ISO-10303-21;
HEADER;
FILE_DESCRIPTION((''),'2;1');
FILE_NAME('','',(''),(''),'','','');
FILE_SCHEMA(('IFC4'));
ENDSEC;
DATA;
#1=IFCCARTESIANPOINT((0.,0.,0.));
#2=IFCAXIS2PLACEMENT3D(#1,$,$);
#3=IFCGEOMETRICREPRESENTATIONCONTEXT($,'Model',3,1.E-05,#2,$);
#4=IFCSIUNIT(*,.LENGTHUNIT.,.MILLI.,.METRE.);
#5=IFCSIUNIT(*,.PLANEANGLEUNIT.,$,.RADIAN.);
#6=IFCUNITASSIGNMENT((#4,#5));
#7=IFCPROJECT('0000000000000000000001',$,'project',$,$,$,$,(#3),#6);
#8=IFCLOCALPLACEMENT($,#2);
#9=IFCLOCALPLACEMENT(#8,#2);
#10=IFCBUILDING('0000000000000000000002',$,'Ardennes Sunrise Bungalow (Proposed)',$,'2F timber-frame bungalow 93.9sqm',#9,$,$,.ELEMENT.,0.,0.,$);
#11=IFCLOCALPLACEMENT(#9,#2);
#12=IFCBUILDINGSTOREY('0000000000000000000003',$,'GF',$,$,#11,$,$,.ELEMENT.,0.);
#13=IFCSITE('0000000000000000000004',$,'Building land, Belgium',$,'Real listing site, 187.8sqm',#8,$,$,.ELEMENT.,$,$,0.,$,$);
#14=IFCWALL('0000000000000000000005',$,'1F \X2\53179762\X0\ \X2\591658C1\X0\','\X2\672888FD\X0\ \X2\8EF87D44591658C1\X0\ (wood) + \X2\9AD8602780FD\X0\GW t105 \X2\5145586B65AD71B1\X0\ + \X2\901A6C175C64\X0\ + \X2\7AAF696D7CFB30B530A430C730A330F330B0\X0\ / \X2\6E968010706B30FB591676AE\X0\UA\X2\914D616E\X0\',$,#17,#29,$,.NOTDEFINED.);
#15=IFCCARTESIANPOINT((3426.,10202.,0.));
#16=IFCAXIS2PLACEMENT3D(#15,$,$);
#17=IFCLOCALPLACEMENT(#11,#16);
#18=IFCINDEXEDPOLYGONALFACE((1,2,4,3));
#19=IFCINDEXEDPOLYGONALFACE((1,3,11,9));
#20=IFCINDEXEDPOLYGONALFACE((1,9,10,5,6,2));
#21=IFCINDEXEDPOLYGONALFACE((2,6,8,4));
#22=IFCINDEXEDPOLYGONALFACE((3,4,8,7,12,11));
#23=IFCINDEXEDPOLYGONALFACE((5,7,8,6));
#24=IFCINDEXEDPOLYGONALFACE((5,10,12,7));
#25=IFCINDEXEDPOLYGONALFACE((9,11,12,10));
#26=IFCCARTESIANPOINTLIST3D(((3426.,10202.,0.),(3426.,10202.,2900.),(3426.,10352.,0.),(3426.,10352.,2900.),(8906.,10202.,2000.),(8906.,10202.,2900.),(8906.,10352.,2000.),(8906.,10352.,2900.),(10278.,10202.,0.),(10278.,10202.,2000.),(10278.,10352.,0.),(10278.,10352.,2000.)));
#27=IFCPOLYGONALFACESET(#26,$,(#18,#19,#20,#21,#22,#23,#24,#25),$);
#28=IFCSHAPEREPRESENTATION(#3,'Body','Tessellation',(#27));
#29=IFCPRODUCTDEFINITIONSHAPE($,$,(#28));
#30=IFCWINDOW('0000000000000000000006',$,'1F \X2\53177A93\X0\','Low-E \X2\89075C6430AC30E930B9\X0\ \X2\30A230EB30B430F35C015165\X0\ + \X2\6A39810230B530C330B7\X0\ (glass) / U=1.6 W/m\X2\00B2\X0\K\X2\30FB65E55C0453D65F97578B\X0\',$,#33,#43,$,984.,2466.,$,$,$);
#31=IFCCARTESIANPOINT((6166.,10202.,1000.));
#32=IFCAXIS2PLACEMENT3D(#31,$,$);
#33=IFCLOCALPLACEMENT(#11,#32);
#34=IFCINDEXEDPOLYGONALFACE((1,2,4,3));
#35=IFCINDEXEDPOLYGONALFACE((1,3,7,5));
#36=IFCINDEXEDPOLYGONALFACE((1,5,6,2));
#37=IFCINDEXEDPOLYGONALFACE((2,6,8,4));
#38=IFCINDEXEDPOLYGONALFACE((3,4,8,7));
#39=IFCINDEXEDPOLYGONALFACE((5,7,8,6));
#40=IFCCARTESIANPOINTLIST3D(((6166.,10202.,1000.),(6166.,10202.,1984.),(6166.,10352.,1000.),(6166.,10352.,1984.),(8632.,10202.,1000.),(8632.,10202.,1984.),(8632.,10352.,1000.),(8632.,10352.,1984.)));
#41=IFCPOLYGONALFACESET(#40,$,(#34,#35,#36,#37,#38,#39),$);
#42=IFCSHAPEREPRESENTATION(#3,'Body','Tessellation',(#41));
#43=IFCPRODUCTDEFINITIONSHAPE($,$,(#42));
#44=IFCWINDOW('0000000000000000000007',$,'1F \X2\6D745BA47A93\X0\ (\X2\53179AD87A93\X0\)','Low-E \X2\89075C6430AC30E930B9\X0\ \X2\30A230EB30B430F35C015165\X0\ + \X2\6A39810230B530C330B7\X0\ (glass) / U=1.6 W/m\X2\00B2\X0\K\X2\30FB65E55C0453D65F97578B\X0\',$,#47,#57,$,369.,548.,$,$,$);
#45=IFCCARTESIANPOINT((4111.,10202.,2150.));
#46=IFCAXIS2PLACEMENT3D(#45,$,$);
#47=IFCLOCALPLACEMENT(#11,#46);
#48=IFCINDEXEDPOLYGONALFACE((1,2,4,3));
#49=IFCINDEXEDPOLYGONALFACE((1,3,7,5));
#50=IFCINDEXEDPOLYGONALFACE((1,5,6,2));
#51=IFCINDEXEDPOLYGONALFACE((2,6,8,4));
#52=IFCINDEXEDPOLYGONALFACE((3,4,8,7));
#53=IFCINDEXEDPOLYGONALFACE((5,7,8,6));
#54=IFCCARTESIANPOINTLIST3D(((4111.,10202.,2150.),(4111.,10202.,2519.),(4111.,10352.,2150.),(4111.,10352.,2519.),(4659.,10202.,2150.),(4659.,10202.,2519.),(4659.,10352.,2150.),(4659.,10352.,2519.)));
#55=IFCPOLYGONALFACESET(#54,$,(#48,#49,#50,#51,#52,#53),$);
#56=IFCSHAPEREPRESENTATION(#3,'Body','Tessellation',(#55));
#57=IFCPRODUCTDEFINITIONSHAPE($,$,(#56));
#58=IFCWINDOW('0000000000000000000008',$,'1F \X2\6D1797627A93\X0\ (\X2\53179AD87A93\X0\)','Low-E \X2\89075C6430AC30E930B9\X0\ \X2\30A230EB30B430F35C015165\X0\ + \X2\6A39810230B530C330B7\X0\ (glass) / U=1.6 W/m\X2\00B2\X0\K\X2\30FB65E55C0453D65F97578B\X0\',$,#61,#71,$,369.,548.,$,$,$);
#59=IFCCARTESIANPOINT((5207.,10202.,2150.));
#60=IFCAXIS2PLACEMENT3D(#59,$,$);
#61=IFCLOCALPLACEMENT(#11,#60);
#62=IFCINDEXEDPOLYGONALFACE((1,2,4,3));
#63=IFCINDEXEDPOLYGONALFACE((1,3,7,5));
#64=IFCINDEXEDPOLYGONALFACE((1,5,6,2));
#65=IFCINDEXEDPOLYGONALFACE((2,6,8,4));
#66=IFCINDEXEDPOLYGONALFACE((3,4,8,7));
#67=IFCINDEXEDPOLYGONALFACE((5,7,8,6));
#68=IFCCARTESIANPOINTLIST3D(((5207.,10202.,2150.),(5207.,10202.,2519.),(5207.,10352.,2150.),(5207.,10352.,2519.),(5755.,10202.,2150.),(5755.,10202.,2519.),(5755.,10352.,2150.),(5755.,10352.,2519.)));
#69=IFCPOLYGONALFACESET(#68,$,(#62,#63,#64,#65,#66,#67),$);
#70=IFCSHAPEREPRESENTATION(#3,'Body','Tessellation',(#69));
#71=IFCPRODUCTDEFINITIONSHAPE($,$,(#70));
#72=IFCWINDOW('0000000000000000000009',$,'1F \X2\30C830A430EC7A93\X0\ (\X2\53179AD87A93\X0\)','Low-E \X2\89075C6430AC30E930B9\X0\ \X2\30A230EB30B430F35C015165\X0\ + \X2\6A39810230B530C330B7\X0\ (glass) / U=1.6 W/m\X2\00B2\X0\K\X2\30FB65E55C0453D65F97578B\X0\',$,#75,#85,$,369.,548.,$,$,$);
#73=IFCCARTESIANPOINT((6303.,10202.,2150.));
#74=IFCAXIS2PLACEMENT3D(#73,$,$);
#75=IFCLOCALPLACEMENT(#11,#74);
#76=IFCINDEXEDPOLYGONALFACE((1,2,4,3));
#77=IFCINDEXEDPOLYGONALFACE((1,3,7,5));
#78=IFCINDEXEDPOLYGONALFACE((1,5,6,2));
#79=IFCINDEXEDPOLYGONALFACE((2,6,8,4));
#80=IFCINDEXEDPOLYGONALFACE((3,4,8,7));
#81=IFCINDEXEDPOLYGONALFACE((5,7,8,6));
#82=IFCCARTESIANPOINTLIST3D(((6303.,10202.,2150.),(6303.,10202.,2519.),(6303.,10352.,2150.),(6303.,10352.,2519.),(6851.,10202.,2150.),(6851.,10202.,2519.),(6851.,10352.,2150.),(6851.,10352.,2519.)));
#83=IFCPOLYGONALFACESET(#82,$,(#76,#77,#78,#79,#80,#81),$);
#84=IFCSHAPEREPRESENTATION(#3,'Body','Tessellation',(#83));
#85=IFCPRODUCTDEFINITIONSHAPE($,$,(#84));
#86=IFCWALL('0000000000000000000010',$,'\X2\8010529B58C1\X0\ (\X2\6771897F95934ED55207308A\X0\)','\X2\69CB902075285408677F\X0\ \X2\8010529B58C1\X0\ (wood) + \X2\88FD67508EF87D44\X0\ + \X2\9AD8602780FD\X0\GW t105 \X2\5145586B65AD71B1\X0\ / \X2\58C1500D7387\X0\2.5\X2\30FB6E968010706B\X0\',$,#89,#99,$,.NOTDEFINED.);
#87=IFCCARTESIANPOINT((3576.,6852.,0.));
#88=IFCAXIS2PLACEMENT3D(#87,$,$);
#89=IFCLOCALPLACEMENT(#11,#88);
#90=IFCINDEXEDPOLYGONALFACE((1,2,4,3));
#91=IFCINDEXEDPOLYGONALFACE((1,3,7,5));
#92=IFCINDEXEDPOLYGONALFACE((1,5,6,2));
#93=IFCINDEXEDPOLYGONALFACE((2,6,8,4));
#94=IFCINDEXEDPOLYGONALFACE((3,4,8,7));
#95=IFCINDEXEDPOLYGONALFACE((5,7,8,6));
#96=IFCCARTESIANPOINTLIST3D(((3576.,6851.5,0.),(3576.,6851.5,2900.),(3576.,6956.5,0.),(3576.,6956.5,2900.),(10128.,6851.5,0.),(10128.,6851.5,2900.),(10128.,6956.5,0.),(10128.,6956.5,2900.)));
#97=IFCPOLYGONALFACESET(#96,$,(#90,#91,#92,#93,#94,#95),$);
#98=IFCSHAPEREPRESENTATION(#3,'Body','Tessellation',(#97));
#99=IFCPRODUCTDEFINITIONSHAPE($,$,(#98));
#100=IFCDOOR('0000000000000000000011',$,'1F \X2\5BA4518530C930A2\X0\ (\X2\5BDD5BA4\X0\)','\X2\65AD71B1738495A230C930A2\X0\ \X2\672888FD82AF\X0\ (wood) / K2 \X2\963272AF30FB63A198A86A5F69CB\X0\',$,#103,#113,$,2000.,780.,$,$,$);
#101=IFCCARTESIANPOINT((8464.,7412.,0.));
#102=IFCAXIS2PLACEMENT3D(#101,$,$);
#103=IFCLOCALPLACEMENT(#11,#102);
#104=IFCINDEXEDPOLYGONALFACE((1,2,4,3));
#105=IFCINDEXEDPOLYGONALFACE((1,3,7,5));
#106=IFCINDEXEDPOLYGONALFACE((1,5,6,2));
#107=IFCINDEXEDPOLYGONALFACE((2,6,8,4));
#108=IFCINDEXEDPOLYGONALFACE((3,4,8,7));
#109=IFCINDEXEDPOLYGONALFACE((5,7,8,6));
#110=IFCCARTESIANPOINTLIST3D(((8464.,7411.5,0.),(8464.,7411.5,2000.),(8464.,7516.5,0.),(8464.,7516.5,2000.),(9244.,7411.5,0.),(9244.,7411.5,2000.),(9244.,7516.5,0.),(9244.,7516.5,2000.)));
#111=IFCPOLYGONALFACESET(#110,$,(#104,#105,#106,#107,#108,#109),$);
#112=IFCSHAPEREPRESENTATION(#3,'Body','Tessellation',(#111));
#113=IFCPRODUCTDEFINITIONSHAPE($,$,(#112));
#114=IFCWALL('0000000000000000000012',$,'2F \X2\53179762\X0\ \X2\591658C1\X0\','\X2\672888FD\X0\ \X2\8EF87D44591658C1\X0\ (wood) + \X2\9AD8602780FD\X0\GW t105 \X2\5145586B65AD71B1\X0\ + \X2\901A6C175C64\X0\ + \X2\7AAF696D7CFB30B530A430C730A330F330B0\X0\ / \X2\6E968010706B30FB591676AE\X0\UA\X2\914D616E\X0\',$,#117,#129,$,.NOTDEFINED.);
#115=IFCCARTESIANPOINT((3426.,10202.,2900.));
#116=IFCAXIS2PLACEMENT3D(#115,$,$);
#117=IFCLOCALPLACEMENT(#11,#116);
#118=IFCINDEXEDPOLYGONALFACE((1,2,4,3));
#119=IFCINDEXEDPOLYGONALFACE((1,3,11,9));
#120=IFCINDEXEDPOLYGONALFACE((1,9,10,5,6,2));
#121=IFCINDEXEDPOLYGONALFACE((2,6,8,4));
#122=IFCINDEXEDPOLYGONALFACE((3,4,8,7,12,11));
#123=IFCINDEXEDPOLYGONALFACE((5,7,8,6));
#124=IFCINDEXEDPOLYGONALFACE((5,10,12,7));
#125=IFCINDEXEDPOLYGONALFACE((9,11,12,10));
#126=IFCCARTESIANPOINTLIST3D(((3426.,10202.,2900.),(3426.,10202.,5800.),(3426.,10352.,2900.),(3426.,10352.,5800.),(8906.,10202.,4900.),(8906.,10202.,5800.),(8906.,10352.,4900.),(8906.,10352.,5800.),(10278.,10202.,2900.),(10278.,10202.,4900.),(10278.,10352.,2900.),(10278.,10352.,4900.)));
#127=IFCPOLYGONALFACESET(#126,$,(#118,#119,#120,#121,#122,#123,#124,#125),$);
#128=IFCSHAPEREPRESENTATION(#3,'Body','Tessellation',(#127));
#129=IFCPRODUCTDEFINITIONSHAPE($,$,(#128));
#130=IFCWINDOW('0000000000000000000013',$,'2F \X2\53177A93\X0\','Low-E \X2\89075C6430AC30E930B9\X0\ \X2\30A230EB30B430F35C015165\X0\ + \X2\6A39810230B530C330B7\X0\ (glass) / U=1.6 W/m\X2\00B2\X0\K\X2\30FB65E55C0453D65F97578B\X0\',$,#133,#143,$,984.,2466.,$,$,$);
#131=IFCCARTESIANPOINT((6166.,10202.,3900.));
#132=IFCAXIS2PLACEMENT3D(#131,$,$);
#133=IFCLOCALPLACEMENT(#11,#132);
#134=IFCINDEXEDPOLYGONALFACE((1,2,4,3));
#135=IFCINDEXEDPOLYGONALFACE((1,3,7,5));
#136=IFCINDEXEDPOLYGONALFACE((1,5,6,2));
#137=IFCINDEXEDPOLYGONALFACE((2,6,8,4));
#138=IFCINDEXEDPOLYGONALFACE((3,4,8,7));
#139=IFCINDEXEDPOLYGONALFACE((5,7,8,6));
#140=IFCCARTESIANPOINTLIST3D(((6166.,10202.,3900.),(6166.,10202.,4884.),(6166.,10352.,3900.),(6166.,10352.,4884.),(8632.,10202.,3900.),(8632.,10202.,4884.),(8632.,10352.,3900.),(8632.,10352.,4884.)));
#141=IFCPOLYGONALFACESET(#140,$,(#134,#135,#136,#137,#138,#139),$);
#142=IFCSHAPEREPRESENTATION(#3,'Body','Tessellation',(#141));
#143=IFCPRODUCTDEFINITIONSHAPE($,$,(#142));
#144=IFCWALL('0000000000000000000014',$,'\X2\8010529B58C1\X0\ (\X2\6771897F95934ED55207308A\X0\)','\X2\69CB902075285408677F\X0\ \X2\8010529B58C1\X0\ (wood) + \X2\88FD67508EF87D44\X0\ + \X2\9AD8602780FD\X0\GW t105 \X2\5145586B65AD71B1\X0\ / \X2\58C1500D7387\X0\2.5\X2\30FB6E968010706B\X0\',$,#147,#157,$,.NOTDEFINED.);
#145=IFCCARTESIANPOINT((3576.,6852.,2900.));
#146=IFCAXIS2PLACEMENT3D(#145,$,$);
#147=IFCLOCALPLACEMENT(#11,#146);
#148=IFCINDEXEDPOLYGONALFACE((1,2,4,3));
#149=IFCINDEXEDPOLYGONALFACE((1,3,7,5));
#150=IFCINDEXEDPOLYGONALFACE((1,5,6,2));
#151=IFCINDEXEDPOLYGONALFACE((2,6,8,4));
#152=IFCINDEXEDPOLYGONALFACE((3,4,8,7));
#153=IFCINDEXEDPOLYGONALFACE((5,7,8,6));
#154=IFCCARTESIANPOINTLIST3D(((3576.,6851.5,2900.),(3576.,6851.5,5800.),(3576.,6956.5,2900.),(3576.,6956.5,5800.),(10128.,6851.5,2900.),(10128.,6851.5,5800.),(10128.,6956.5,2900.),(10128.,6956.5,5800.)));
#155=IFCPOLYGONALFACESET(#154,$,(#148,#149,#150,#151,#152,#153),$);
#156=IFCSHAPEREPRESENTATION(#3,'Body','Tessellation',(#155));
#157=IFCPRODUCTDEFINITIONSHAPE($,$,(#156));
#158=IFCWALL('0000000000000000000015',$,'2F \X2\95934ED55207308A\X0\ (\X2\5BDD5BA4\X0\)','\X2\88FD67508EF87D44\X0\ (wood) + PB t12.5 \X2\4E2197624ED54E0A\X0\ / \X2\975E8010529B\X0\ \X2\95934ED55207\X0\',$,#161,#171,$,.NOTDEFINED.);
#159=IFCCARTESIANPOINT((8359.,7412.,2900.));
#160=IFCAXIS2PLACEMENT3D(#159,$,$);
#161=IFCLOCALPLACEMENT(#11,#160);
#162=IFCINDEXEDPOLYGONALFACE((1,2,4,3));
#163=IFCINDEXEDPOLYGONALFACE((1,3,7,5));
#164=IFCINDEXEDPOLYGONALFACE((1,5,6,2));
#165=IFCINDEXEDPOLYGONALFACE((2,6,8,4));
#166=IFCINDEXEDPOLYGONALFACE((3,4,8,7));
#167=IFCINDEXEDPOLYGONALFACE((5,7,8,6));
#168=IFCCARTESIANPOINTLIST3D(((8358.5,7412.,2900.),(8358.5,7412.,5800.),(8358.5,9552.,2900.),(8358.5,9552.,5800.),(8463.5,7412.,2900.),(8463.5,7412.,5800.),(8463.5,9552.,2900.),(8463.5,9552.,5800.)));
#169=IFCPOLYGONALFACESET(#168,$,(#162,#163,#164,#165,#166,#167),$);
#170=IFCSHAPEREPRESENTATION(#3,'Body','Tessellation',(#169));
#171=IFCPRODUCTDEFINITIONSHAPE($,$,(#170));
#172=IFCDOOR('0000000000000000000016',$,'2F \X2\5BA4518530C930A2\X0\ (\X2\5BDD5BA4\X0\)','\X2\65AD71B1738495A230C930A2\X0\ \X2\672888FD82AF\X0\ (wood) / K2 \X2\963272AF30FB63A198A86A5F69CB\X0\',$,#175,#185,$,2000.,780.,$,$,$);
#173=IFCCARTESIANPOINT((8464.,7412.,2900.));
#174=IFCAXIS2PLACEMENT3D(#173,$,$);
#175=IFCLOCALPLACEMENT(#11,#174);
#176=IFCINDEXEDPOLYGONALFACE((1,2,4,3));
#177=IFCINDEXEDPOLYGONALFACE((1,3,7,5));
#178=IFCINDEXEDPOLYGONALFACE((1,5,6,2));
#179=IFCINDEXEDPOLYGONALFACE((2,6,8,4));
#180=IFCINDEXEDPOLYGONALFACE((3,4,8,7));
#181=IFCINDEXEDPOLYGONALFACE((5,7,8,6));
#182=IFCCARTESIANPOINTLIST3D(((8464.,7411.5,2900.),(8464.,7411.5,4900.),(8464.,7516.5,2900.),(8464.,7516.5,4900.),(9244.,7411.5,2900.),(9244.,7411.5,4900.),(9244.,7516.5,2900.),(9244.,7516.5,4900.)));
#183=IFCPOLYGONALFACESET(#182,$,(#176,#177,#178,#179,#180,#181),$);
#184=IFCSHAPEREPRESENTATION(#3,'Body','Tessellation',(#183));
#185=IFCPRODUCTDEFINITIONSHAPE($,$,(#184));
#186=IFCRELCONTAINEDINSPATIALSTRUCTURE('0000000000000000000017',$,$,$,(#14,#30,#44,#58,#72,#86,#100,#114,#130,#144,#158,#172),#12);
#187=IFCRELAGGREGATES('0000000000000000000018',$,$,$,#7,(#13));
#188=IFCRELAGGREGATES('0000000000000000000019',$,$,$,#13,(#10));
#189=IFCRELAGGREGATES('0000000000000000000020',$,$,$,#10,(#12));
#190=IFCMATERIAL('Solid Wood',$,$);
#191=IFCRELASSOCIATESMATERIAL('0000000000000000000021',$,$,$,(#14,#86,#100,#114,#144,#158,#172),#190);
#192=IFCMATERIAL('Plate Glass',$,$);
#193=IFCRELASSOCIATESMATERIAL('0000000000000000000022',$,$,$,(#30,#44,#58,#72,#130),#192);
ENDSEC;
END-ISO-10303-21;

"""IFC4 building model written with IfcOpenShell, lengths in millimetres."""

from ifc_helpers import new_model, si_unit, frame, frame_2d, origin, place, context, project, spatial, rectangle, extrude, material, element, fill, save


model = new_model("IFC4")

# Units and contexts
model_context = context("Model", 3, precision=1e-05, world=origin())
ifc_project = project(units=[si_unit("LENGTHUNIT", "METRE", prefix="MILLI"), si_unit("PLANEANGLEUNIT", "RADIAN")], contexts=[model_context])

# Site, building, storey
site_placement = place(None, origin())
site = spatial("IfcSite", under=ifc_project, at=site_placement, Name="Building land, Belgium", ObjectType="Real listing site, 187.8sqm", CompositionType="ELEMENT", RefElevation=0.0)
building_placement = place(site_placement, origin())
building = spatial("IfcBuilding", under=site, at=building_placement, Name="Ardennes Sunrise Bungalow (Proposed)", ObjectType="2F timber-frame bungalow 93.9sqm", CompositionType="ELEMENT", ElevationOfRefHeight=0.0, ElevationOfTerrain=0.0)
storey_placement = place(building_placement, origin())
storey = spatial("IfcBuildingStorey", under=building, at=storey_placement, Name="GF", CompositionType="ELEMENT", Elevation=0.0)

# Wall, openings, windows
ifc_material_1 = material(Name="Solid Wood")
wall_1_placement = place(storey_placement, frame((3426.0, 10202.0, 0.0)))
wall_1 = element("IfcWall", 1, at=wall_1_placement, inside=storey, material=ifc_material_1, Name="1F 北面 外壁", Description="木製 軸組外壁 (wood) + 高性能GW t105 充填断熱 + 通気層 + 窯業系サイディング / 準耐火・外皮UA配慮", PredefinedType="NOTDEFINED", context=model_context, shape_type="SweptSolid", body=[
    extrude(rectangle(XDim=6852.0, YDim=150.0, at=frame_2d((3426.0, 75.0))), frame((3426.0, 10202.0, 0.0)), (0.0, 0.0, 1.0), 2900.0),
])
opening_1_placement = place(storey_placement, frame((6166.0, 10202.0, 1000.0)))
opening_1 = element("IfcOpeningElement", 2, at=opening_1_placement, cuts=wall_1, PredefinedType="NOTDEFINED", context=model_context, shape_type="SweptSolid", body=[
    extrude(rectangle(XDim=2466.0, YDim=150.0, at=frame_2d((1233.0, 75.0))), frame((6166.0, 10202.0, 1000.0)), (0.0, 0.0, 1.0), 984.0),
])
opening_2_placement = place(storey_placement, frame((4111.0, 10202.0, 2150.0)))
opening_2 = element("IfcOpeningElement", 3, at=opening_2_placement, cuts=wall_1, PredefinedType="NOTDEFINED", context=model_context, shape_type="SweptSolid", body=[
    extrude(rectangle(XDim=548.0, YDim=150.0, at=frame_2d((274.0, 75.0))), frame((4111.0, 10202.0, 2150.0)), (0.0, 0.0, 1.0), 369.0),
])
opening_3_placement = place(storey_placement, frame((5207.0, 10202.0, 2150.0)))
opening_3 = element("IfcOpeningElement", 4, at=opening_3_placement, cuts=wall_1, PredefinedType="NOTDEFINED", context=model_context, shape_type="SweptSolid", body=[
    extrude(rectangle(XDim=548.0, YDim=150.0, at=frame_2d((274.0, 75.0))), frame((5207.0, 10202.0, 2150.0)), (0.0, 0.0, 1.0), 369.0),
])
opening_4_placement = place(storey_placement, frame((6303.0, 10202.0, 2150.0)))
opening_4 = element("IfcOpeningElement", 5, at=opening_4_placement, cuts=wall_1, PredefinedType="NOTDEFINED", context=model_context, shape_type="SweptSolid", body=[
    extrude(rectangle(XDim=548.0, YDim=150.0, at=frame_2d((274.0, 75.0))), frame((6303.0, 10202.0, 2150.0)), (0.0, 0.0, 1.0), 369.0),
])
ifc_material_2 = material(Name="Plate Glass")
window_1_placement = place(storey_placement, frame((6166.0, 10202.0, 1000.0)))
window_1 = element("IfcWindow", 6, at=window_1_placement, inside=storey, material=ifc_material_2, Name="1F 北窓", Description="Low-E 複層ガラス アルゴン封入 + 樹脂サッシ (glass) / U=1.6 W/m²K・日射取得型", OverallHeight=984.0, OverallWidth=2466.0, context=model_context, shape_type="SweptSolid", body=[
    extrude(rectangle(XDim=2466.0, YDim=150.0, at=frame_2d((1233.0, 75.0))), frame((6166.0, 10202.0, 1000.0)), (0.0, 0.0, 1.0), 984.0),
])
fill(opening_1, window_1)
window_2_placement = place(storey_placement, frame((4111.0, 10202.0, 2150.0)))
window_2 = element("IfcWindow", 7, at=window_2_placement, inside=storey, material=ifc_material_2, Name="1F 浴室窓 (北高窓)", Description="Low-E 複層ガラス アルゴン封入 + 樹脂サッシ (glass) / U=1.6 W/m²K・日射取得型", OverallHeight=369.0, OverallWidth=548.0, context=model_context, shape_type="SweptSolid", body=[
    extrude(rectangle(XDim=548.0, YDim=150.0, at=frame_2d((274.0, 75.0))), frame((4111.0, 10202.0, 2150.0)), (0.0, 0.0, 1.0), 369.0),
])
fill(opening_2, window_2)
window_3_placement = place(storey_placement, frame((5207.0, 10202.0, 2150.0)))
window_3 = element("IfcWindow", 8, at=window_3_placement, inside=storey, material=ifc_material_2, Name="1F 洗面窓 (北高窓)", Description="Low-E 複層ガラス アルゴン封入 + 樹脂サッシ (glass) / U=1.6 W/m²K・日射取得型", OverallHeight=369.0, OverallWidth=548.0, context=model_context, shape_type="SweptSolid", body=[
    extrude(rectangle(XDim=548.0, YDim=150.0, at=frame_2d((274.0, 75.0))), frame((5207.0, 10202.0, 2150.0)), (0.0, 0.0, 1.0), 369.0),
])
fill(opening_3, window_3)
window_4_placement = place(storey_placement, frame((6303.0, 10202.0, 2150.0)))
window_4 = element("IfcWindow", 9, at=window_4_placement, inside=storey, material=ifc_material_2, Name="1F トイレ窓 (北高窓)", Description="Low-E 複層ガラス アルゴン封入 + 樹脂サッシ (glass) / U=1.6 W/m²K・日射取得型", OverallHeight=369.0, OverallWidth=548.0, context=model_context, shape_type="SweptSolid", body=[
    extrude(rectangle(XDim=548.0, YDim=150.0, at=frame_2d((274.0, 75.0))), frame((6303.0, 10202.0, 2150.0)), (0.0, 0.0, 1.0), 369.0),
])
fill(opening_4, window_4)

# Wall
wall_2_placement = place(storey_placement, frame((3576.0, 6852.0, 0.0)))
element("IfcWall", 10, at=wall_2_placement, inside=storey, material=ifc_material_1, Name="耐力壁 (東西間仕切り)", Description="構造用合板 耐力壁 (wood) + 製材軸組 + 高性能GW t105 充填断熱 / 壁倍率2.5・準耐火", PredefinedType="NOTDEFINED", context=model_context, shape_type="SweptSolid", body=[
    extrude(rectangle(XDim=6552.0, YDim=105.0, at=frame_2d((3276.0, 52.0))), frame((3576.0, 6852.0, 0.0)), (0.0, 0.0, 1.0), 2900.0),
])

# Door
door_1_placement = place(storey_placement, frame((8464.0, 7412.0, 0.0)))
element("IfcDoor", 11, at=door_1_placement, inside=storey, material=ifc_material_1, Name="1F 室内ドア (寝室)", Description="断熱玄関ドア 木製芯 (wood) / K2 防犯・採風機構", OverallHeight=2000.0, OverallWidth=780.0, context=model_context, shape_type="SweptSolid", body=[
    extrude(rectangle(XDim=780.0, YDim=105.0, at=frame_2d((390.0, 52.0))), frame((8464.0, 7412.0, 0.0)), (0.0, 0.0, 1.0), 2000.0),
])

# Wall, opening, window
wall_3_placement = place(storey_placement, frame((3426.0, 10202.0, 2900.0)))
wall_3 = element("IfcWall", 12, at=wall_3_placement, inside=storey, material=ifc_material_1, Name="2F 北面 外壁", Description="木製 軸組外壁 (wood) + 高性能GW t105 充填断熱 + 通気層 + 窯業系サイディング / 準耐火・外皮UA配慮", PredefinedType="NOTDEFINED", context=model_context, shape_type="SweptSolid", body=[
    extrude(rectangle(XDim=6852.0, YDim=150.0, at=frame_2d((3426.0, 75.0))), frame((3426.0, 10202.0, 2900.0)), (0.0, 0.0, 1.0), 2900.0),
])
opening_5_placement = place(storey_placement, frame((6166.0, 10202.0, 3900.0)))
opening_5 = element("IfcOpeningElement", 13, at=opening_5_placement, cuts=wall_3, PredefinedType="NOTDEFINED", context=model_context, shape_type="SweptSolid", body=[
    extrude(rectangle(XDim=2466.0, YDim=150.0, at=frame_2d((1233.0, 75.0))), frame((6166.0, 10202.0, 3900.0)), (0.0, 0.0, 1.0), 984.0),
])
window_5_placement = place(storey_placement, frame((6166.0, 10202.0, 3900.0)))
window_5 = element("IfcWindow", 14, at=window_5_placement, inside=storey, material=ifc_material_2, Name="2F 北窓", Description="Low-E 複層ガラス アルゴン封入 + 樹脂サッシ (glass) / U=1.6 W/m²K・日射取得型", OverallHeight=984.0, OverallWidth=2466.0, context=model_context, shape_type="SweptSolid", body=[
    extrude(rectangle(XDim=2466.0, YDim=150.0, at=frame_2d((1233.0, 75.0))), frame((6166.0, 10202.0, 3900.0)), (0.0, 0.0, 1.0), 984.0),
])
fill(opening_5, window_5)

# Walls
wall_4_placement = place(storey_placement, frame((3576.0, 6852.0, 2900.0)))
element("IfcWall", 15, at=wall_4_placement, inside=storey, material=ifc_material_1, Name="耐力壁 (東西間仕切り)", Description="構造用合板 耐力壁 (wood) + 製材軸組 + 高性能GW t105 充填断熱 / 壁倍率2.5・準耐火", PredefinedType="NOTDEFINED", context=model_context, shape_type="SweptSolid", body=[
    extrude(rectangle(XDim=6552.0, YDim=105.0, at=frame_2d((3276.0, 52.0))), frame((3576.0, 6852.0, 2900.0)), (0.0, 0.0, 1.0), 2900.0),
])
wall_5_placement = place(storey_placement, frame((8359.0, 7412.0, 2900.0)))
element("IfcWall", 16, at=wall_5_placement, inside=storey, material=ifc_material_1, Name="2F 間仕切り (寝室)", Description="製材軸組 (wood) + PB t12.5 両面仕上 / 非耐力 間仕切", PredefinedType="NOTDEFINED", context=model_context, shape_type="SweptSolid", body=[
    extrude(rectangle(XDim=105.0, YDim=2140.0, at=frame_2d((52.0, 1070.0))), frame((8359.0, 7412.0, 2900.0)), (0.0, 0.0, 1.0), 2900.0),
])

# Door
door_2_placement = place(storey_placement, frame((8464.0, 7412.0, 2900.0)))
element("IfcDoor", 17, at=door_2_placement, inside=storey, material=ifc_material_1, Name="2F 室内ドア (寝室)", Description="断熱玄関ドア 木製芯 (wood) / K2 防犯・採風機構", OverallHeight=2000.0, OverallWidth=780.0, context=model_context, shape_type="SweptSolid", body=[
    extrude(rectangle(XDim=780.0, YDim=105.0, at=frame_2d((390.0, 52.0))), frame((8464.0, 7412.0, 2900.0)), (0.0, 0.0, 1.0), 2000.0),
])

save(model, "model.ifc")
